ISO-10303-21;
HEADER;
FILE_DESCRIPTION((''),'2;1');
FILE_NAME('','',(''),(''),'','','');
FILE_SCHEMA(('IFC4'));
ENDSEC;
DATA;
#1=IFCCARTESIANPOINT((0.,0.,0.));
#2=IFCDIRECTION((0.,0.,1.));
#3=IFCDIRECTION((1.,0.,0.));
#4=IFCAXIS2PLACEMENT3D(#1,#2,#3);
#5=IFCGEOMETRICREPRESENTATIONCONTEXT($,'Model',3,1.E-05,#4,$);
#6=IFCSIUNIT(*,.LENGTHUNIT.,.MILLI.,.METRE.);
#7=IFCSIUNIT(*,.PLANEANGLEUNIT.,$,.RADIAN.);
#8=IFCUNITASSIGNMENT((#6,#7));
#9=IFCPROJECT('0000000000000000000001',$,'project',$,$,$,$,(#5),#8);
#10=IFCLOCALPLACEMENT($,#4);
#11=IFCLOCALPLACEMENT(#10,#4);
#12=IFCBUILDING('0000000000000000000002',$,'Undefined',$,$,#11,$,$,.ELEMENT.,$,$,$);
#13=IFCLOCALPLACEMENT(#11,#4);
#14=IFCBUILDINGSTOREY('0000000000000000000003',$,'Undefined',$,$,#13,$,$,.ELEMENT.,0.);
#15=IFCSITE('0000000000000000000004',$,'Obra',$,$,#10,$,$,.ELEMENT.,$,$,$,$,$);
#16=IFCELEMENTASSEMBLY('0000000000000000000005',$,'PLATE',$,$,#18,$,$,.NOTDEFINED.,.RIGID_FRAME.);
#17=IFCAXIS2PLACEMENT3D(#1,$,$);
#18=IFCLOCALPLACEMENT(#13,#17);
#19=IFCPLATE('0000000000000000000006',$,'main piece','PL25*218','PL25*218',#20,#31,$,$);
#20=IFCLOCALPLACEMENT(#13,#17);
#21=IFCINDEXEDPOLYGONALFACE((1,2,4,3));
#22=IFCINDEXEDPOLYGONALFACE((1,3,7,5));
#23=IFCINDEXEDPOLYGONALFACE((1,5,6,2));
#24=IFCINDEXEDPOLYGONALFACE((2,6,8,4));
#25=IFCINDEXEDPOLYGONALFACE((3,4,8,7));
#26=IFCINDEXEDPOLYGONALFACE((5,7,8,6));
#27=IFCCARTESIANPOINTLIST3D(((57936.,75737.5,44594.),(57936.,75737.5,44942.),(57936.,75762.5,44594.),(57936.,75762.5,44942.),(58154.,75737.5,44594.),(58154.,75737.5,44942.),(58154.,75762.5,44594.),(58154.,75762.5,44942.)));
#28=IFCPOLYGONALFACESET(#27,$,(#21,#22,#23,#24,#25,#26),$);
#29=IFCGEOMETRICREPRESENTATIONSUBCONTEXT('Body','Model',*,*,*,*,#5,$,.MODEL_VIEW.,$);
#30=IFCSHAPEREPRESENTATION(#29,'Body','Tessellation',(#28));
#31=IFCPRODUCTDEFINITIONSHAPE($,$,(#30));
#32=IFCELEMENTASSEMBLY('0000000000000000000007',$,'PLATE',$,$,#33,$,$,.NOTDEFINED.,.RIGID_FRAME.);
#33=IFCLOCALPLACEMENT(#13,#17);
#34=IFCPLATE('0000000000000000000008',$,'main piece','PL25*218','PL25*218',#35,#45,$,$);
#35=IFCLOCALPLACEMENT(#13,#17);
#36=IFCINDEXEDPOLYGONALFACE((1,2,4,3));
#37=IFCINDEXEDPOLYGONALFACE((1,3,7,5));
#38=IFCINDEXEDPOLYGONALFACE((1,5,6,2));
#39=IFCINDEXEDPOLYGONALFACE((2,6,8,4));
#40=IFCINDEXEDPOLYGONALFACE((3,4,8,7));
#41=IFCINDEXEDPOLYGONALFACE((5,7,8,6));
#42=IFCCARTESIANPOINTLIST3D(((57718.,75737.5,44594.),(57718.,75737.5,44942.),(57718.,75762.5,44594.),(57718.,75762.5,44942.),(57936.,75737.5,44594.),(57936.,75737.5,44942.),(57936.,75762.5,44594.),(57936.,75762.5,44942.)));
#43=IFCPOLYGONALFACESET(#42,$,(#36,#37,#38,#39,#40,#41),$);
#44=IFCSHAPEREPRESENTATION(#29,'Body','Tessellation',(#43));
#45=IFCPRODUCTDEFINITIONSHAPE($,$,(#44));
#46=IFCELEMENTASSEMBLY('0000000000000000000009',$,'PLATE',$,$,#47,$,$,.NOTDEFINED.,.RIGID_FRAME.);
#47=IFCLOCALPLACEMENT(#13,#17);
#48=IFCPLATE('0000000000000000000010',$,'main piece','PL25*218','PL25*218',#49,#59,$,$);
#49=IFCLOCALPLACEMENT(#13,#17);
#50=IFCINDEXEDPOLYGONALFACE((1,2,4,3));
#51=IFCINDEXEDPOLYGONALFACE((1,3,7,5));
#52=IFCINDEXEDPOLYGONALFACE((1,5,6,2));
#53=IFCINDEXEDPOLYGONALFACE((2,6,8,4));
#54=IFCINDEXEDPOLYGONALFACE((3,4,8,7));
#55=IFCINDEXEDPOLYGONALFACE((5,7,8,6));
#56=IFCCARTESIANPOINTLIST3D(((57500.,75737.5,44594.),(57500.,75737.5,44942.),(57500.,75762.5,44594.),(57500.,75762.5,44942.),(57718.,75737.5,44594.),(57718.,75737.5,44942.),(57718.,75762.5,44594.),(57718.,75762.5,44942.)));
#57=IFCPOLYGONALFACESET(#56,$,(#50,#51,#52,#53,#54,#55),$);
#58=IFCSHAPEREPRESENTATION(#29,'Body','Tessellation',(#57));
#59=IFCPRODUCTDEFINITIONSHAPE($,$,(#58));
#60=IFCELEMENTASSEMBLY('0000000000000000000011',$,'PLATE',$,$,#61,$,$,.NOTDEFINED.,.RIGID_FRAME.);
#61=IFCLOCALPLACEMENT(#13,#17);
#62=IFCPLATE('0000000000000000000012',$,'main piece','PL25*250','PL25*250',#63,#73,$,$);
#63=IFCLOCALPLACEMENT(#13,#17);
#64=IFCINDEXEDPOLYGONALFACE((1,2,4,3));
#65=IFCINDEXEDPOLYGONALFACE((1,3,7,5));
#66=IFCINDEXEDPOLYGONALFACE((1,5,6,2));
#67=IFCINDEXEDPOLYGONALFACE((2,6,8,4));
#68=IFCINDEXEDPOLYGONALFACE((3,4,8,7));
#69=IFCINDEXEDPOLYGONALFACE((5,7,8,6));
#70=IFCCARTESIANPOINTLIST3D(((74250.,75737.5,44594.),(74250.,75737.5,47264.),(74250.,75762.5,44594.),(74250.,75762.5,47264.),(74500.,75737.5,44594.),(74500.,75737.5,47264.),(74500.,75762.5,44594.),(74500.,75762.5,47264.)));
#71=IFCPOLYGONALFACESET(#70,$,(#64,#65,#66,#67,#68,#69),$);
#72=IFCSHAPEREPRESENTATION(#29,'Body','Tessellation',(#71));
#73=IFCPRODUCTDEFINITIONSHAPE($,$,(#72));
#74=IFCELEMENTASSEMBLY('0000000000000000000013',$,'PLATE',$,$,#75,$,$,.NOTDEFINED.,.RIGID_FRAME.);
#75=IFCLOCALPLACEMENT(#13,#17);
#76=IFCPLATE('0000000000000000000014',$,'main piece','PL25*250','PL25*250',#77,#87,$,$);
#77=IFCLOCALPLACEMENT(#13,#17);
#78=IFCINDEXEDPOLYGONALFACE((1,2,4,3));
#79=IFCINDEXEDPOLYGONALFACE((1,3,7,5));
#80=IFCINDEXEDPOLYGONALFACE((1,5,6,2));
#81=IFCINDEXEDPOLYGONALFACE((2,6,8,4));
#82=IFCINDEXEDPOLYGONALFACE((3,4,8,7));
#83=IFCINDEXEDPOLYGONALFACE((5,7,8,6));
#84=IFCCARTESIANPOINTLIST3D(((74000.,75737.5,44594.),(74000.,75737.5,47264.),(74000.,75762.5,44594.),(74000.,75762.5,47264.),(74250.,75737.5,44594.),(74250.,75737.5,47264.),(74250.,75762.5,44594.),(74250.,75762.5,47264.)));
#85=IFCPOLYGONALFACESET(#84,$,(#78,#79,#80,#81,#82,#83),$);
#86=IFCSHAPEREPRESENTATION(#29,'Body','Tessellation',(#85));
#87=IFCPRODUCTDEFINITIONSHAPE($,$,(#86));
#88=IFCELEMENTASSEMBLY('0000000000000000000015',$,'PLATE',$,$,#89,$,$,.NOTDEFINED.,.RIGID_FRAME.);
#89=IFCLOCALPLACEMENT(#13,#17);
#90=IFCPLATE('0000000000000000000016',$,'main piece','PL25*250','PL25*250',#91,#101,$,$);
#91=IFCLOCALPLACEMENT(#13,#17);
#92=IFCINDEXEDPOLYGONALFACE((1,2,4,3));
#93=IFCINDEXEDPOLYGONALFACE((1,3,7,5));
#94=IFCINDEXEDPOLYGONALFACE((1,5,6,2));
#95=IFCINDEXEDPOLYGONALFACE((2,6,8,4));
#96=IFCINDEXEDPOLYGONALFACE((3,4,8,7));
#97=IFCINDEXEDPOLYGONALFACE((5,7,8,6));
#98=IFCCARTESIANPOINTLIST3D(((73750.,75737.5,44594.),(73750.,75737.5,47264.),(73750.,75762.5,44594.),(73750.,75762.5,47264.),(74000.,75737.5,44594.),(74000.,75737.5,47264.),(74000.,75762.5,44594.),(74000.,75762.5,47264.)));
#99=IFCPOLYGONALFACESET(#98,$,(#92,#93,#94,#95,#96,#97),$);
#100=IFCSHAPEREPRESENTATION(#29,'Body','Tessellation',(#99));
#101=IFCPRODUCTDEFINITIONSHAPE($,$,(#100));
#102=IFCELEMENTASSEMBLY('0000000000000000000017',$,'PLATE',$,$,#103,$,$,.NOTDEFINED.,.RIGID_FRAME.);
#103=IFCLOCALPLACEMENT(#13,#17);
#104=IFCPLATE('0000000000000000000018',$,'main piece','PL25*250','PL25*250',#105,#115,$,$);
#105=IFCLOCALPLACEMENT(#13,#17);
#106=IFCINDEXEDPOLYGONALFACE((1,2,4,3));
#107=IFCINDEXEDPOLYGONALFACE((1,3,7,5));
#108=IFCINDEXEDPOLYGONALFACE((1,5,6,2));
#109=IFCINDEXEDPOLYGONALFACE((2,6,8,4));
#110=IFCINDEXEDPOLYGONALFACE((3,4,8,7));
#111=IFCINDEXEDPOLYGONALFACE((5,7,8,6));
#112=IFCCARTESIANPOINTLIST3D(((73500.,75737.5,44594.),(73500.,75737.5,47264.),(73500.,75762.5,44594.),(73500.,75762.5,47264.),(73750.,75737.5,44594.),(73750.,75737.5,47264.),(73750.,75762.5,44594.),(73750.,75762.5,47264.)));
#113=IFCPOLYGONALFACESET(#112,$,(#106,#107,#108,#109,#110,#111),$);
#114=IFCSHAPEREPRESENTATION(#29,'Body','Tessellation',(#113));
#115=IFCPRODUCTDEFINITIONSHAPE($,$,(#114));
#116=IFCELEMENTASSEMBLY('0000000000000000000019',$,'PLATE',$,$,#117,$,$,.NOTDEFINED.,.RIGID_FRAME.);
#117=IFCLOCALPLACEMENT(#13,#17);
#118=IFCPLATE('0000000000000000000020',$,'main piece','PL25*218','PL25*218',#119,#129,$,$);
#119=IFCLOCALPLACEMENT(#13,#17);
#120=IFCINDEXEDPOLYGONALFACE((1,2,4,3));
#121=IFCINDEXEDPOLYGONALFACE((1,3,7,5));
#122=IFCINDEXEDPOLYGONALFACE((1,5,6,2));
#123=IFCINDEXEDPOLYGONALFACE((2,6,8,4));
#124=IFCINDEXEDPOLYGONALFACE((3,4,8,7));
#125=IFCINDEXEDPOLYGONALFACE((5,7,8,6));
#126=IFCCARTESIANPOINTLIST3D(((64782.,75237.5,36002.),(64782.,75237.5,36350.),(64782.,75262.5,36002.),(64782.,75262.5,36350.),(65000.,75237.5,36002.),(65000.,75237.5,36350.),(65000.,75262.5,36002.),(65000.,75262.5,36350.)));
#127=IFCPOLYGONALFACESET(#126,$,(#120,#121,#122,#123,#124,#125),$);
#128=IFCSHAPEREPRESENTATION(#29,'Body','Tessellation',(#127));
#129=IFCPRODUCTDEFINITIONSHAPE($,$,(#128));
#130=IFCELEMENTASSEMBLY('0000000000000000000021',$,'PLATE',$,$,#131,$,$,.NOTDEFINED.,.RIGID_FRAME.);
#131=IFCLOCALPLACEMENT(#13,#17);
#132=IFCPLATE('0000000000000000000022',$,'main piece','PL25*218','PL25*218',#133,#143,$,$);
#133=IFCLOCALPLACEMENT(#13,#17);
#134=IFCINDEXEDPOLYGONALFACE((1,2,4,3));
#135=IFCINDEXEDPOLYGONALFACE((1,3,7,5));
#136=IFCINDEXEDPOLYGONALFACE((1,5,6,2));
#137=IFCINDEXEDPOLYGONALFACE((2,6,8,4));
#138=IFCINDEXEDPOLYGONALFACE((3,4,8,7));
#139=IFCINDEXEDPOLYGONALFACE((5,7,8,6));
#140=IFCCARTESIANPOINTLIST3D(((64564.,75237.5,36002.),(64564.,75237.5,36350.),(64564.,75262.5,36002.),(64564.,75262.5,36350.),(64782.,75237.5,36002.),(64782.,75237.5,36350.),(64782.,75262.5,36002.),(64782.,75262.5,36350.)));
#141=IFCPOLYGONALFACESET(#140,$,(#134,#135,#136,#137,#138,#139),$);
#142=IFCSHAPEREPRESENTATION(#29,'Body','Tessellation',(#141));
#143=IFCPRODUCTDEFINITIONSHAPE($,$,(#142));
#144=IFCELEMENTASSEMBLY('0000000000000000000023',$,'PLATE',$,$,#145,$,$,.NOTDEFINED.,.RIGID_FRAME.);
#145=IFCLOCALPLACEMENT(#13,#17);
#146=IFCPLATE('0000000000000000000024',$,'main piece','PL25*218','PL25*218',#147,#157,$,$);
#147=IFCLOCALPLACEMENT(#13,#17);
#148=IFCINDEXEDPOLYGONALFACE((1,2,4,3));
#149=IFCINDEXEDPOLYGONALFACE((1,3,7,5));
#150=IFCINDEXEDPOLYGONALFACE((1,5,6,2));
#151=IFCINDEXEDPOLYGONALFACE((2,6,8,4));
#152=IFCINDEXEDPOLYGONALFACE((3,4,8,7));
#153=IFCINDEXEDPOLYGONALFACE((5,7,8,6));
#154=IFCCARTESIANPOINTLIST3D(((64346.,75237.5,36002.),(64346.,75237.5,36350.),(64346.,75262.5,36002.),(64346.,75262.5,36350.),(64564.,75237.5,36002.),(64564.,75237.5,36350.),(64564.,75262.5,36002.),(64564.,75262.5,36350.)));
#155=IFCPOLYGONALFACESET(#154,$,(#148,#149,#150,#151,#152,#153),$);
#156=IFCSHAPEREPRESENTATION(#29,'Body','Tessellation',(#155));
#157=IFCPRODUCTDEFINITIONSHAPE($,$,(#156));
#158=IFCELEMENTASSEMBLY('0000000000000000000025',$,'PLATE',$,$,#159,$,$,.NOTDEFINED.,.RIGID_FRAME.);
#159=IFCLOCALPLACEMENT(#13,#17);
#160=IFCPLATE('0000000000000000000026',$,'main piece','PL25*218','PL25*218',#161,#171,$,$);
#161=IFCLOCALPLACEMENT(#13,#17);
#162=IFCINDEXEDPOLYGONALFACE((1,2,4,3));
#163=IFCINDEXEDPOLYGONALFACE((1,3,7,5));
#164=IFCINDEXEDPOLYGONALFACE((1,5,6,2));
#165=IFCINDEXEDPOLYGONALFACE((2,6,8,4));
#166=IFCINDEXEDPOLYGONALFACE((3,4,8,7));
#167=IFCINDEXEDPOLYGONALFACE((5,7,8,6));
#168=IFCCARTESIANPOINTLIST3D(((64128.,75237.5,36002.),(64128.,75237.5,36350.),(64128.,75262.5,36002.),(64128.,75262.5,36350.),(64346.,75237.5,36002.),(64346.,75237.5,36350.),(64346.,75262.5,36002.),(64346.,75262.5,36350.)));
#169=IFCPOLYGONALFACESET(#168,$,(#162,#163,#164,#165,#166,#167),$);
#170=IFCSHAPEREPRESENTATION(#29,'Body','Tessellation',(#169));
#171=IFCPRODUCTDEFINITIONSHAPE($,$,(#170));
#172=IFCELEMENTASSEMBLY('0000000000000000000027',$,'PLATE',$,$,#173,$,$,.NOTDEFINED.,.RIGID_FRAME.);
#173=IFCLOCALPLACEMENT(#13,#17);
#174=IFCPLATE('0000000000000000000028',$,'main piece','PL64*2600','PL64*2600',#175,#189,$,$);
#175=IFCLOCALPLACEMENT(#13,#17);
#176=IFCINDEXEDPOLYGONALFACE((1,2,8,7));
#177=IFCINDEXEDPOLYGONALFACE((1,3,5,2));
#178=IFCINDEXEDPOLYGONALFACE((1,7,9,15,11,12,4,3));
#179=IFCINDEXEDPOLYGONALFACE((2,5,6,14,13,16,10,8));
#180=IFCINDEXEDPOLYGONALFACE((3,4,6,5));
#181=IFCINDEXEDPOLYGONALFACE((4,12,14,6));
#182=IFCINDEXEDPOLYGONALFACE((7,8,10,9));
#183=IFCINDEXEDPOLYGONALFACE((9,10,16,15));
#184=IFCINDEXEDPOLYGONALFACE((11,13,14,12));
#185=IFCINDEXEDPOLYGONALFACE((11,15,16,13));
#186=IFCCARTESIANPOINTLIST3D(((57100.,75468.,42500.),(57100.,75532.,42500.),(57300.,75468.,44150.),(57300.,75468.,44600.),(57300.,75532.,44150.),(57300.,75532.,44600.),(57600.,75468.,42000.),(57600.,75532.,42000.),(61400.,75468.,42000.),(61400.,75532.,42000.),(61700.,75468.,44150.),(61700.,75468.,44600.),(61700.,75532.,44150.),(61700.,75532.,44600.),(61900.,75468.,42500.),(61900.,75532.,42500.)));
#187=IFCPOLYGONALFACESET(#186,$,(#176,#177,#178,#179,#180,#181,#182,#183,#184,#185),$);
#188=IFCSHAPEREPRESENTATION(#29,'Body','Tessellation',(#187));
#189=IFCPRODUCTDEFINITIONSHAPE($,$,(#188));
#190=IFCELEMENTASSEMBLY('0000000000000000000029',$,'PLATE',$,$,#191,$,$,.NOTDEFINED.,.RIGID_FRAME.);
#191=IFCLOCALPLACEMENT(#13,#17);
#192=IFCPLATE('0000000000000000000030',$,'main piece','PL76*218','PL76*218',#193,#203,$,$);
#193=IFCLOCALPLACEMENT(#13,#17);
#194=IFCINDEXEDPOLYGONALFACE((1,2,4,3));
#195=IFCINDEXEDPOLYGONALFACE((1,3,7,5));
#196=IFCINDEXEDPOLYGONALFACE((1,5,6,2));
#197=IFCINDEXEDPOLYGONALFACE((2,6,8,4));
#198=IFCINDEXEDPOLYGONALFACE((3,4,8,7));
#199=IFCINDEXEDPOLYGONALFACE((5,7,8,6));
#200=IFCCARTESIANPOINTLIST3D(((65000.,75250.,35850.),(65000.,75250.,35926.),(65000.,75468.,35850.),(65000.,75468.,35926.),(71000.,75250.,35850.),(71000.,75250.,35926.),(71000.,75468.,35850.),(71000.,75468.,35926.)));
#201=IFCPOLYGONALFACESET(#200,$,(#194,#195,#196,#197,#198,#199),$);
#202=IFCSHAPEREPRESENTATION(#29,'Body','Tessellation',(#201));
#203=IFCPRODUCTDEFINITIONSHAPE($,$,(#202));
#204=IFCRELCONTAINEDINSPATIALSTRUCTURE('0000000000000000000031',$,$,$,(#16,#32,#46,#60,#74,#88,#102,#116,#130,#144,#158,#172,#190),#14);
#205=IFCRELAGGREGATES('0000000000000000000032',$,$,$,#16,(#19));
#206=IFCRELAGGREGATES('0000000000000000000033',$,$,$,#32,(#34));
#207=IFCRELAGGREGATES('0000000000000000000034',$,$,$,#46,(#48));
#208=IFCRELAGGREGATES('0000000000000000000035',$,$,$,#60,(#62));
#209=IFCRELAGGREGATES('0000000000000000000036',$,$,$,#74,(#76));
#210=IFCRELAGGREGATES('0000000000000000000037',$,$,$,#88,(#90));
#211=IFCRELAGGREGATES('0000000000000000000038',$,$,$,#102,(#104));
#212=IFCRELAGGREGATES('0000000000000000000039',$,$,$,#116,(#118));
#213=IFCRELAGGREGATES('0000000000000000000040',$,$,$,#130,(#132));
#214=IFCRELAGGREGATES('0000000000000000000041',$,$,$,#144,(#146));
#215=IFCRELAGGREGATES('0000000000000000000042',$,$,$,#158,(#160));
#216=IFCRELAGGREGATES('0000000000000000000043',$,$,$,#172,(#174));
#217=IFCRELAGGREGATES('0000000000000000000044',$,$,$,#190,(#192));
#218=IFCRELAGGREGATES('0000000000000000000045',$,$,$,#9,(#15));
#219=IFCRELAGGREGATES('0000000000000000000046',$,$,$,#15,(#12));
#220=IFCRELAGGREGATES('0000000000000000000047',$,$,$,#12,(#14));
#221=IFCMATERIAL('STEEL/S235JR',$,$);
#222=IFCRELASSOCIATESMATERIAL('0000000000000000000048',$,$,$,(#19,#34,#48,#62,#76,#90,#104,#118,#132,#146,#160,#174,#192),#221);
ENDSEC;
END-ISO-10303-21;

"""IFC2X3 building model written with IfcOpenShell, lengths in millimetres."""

from ifc_helpers import new_model, si_unit, frame, origin_with_axes, place, context, subcontext, project, spatial, polyline, outline, extrude, material, element, aggregate, save


model = new_model("IFC2X3")

# Units and contexts
model_context = context("Model", 3, precision=1e-05, world=origin_with_axes())
body_context = subcontext(model_context, "Body", "Model", "MODEL_VIEW")
ifc_project = project(units=[si_unit("LENGTHUNIT", "METRE", prefix="MILLI"), si_unit("PLANEANGLEUNIT", "RADIAN")], contexts=[model_context])

# Site, building, storey
site_placement = place(None, origin_with_axes())
site = spatial("IfcSite", under=ifc_project, at=site_placement, Name="Obra", CompositionType="ELEMENT")
building_placement = place(site_placement, origin_with_axes())
building = spatial("IfcBuilding", under=site, at=building_placement, Name="Undefined", CompositionType="ELEMENT")
storey_placement = place(building_placement, origin_with_axes())
storey = spatial("IfcBuildingStorey", under=building, at=storey_placement, Name="Undefined", CompositionType="ELEMENT", Elevation=0.0)

# Shared definitions
ifc_material = material(Name="STEEL/S235JR")

# Element assemblies, plates
assembly_1_placement = place(storey_placement, origin_with_axes())
assembly_1 = element("IfcElementAssembly", 1, at=assembly_1_placement, inside=storey, Name="PLATE", AssemblyPlace="NOTDEFINED", PredefinedType="RIGID_FRAME")
plate_1_placement = place(assembly_1_placement, frame((57936.0, 75750.0, 44594.0), z_axis=(0.0, -1.0, 0.0), x_axis=(1.0, 0.0, 0.0)))
plate_1 = element("IfcPlate", 2, at=plate_1_placement, material=ifc_material, Name="main piece", Description="PL25*218", ObjectType="PL25*218", context=body_context, shape_type="SweptSolid", body=[
    extrude(outline(polyline([(0.0, 0.0), (218.0, 0.0), (218.0, 348.0), (0.0, 348.0), (0.0, 0.0)])), frame((0.0, 0.0, -12.5), z_axis=(0.0, 0.0, 1.0), x_axis=(1.0, 0.0, 0.0)), (0.0, 0.0, 1.0), 25.0),
])
aggregate(assembly_1, [plate_1])
assembly_2_placement = place(storey_placement, origin_with_axes())
assembly_2 = element("IfcElementAssembly", 3, at=assembly_2_placement, inside=storey, Name="PLATE", AssemblyPlace="NOTDEFINED", PredefinedType="RIGID_FRAME")
plate_2_placement = place(assembly_2_placement, frame((57718.0, 75750.0, 44594.0), z_axis=(0.0, -1.0, 0.0), x_axis=(1.0, 0.0, 0.0)))
plate_2 = element("IfcPlate", 4, at=plate_2_placement, material=ifc_material, Name="main piece", Description="PL25*218", ObjectType="PL25*218", context=body_context, shape_type="SweptSolid", body=[
    extrude(outline(polyline([(0.0, 0.0), (218.0, 0.0), (218.0, 348.0), (0.0, 348.0), (0.0, 0.0)])), frame((0.0, 0.0, -12.5), z_axis=(0.0, 0.0, 1.0), x_axis=(1.0, 0.0, 0.0)), (0.0, 0.0, 1.0), 25.0),
])
aggregate(assembly_2, [plate_2])
assembly_3_placement = place(storey_placement, origin_with_axes())
assembly_3 = element("IfcElementAssembly", 5, at=assembly_3_placement, inside=storey, Name="PLATE", AssemblyPlace="NOTDEFINED", PredefinedType="RIGID_FRAME")
plate_3_placement = place(assembly_3_placement, frame((57500.0, 75750.0, 44594.0), z_axis=(0.0, -1.0, 0.0), x_axis=(1.0, 0.0, 0.0)))
plate_3 = element("IfcPlate", 6, at=plate_3_placement, material=ifc_material, Name="main piece", Description="PL25*218", ObjectType="PL25*218", context=body_context, shape_type="SweptSolid", body=[
    extrude(outline(polyline([(0.0, 0.0), (218.0, 0.0), (218.0, 348.0), (0.0, 348.0), (0.0, 0.0)])), frame((0.0, 0.0, -12.5), z_axis=(0.0, 0.0, 1.0), x_axis=(1.0, 0.0, 0.0)), (0.0, 0.0, 1.0), 25.0),
])
aggregate(assembly_3, [plate_3])
assembly_4_placement = place(storey_placement, origin_with_axes())
assembly_4 = element("IfcElementAssembly", 7, at=assembly_4_placement, inside=storey, Name="PLATE", AssemblyPlace="NOTDEFINED", PredefinedType="RIGID_FRAME")
plate_4_placement = place(assembly_4_placement, frame((74250.0, 75750.0, 44594.0), z_axis=(0.0, -1.0, 0.0), x_axis=(1.0, 0.0, 0.0)))
plate_4 = element("IfcPlate", 8, at=plate_4_placement, material=ifc_material, Name="main piece", Description="PL25*250", ObjectType="PL25*250", context=body_context, shape_type="SweptSolid", body=[
    extrude(outline(polyline([(0.0, 0.0), (250.0, 0.0), (250.0, 2670.0), (0.0, 2670.0), (0.0, 0.0)])), frame((0.0, 0.0, -12.5), z_axis=(0.0, 0.0, 1.0), x_axis=(1.0, 0.0, 0.0)), (0.0, 0.0, 1.0), 25.0),
])
aggregate(assembly_4, [plate_4])
assembly_5_placement = place(storey_placement, origin_with_axes())
assembly_5 = element("IfcElementAssembly", 9, at=assembly_5_placement, inside=storey, Name="PLATE", AssemblyPlace="NOTDEFINED", PredefinedType="RIGID_FRAME")
plate_5_placement = place(assembly_5_placement, frame((74000.0, 75750.0, 44594.0), z_axis=(0.0, -1.0, 0.0), x_axis=(1.0, 0.0, 0.0)))
plate_5 = element("IfcPlate", 10, at=plate_5_placement, material=ifc_material, Name="main piece", Description="PL25*250", ObjectType="PL25*250", context=body_context, shape_type="SweptSolid", body=[
    extrude(outline(polyline([(0.0, 0.0), (250.0, 0.0), (250.0, 2670.0), (0.0, 2670.0), (0.0, 0.0)])), frame((0.0, 0.0, -12.5), z_axis=(0.0, 0.0, 1.0), x_axis=(1.0, 0.0, 0.0)), (0.0, 0.0, 1.0), 25.0),
])
aggregate(assembly_5, [plate_5])
assembly_6_placement = place(storey_placement, origin_with_axes())
assembly_6 = element("IfcElementAssembly", 11, at=assembly_6_placement, inside=storey, Name="PLATE", AssemblyPlace="NOTDEFINED", PredefinedType="RIGID_FRAME")
plate_6_placement = place(assembly_6_placement, frame((73750.0, 75750.0, 44594.0), z_axis=(0.0, -1.0, 0.0), x_axis=(1.0, 0.0, 0.0)))
plate_6 = element("IfcPlate", 12, at=plate_6_placement, material=ifc_material, Name="main piece", Description="PL25*250", ObjectType="PL25*250", context=body_context, shape_type="SweptSolid", body=[
    extrude(outline(polyline([(0.0, 0.0), (250.0, 0.0), (250.0, 2670.0), (0.0, 2670.0), (0.0, 0.0)])), frame((0.0, 0.0, -12.5), z_axis=(0.0, 0.0, 1.0), x_axis=(1.0, 0.0, 0.0)), (0.0, 0.0, 1.0), 25.0),
])
aggregate(assembly_6, [plate_6])
assembly_7_placement = place(storey_placement, origin_with_axes())
assembly_7 = element("IfcElementAssembly", 13, at=assembly_7_placement, inside=storey, Name="PLATE", AssemblyPlace="NOTDEFINED", PredefinedType="RIGID_FRAME")
plate_7_placement = place(assembly_7_placement, frame((73500.0, 75750.0, 44594.0), z_axis=(0.0, -1.0, 0.0), x_axis=(1.0, 0.0, 0.0)))
plate_7 = element("IfcPlate", 14, at=plate_7_placement, material=ifc_material, Name="main piece", Description="PL25*250", ObjectType="PL25*250", context=body_context, shape_type="SweptSolid", body=[
    extrude(outline(polyline([(0.0, 0.0), (250.0, 0.0), (250.0, 2670.0), (0.0, 2670.0), (0.0, 0.0)])), frame((0.0, 0.0, -12.5), z_axis=(0.0, 0.0, 1.0), x_axis=(1.0, 0.0, 0.0)), (0.0, 0.0, 1.0), 25.0),
])
aggregate(assembly_7, [plate_7])
assembly_8_placement = place(storey_placement, origin_with_axes())
assembly_8 = element("IfcElementAssembly", 15, at=assembly_8_placement, inside=storey, Name="PLATE", AssemblyPlace="NOTDEFINED", PredefinedType="RIGID_FRAME")
plate_8_placement = place(assembly_8_placement, frame((64782.0, 75250.0, 36002.0), z_axis=(0.0, -1.0, 0.0), x_axis=(1.0, 0.0, 0.0)))
plate_8 = element("IfcPlate", 16, at=plate_8_placement, material=ifc_material, Name="main piece", Description="PL25*218", ObjectType="PL25*218", context=body_context, shape_type="SweptSolid", body=[
    extrude(outline(polyline([(0.0, 0.0), (218.0, 0.0), (218.0, 348.0), (0.0, 348.0), (0.0, 0.0)])), frame((0.0, 0.0, -12.5), z_axis=(0.0, 0.0, 1.0), x_axis=(1.0, 0.0, 0.0)), (0.0, 0.0, 1.0), 25.0),
])
aggregate(assembly_8, [plate_8])
assembly_9_placement = place(storey_placement, origin_with_axes())
assembly_9 = element("IfcElementAssembly", 17, at=assembly_9_placement, inside=storey, Name="PLATE", AssemblyPlace="NOTDEFINED", PredefinedType="RIGID_FRAME")
plate_9_placement = place(assembly_9_placement, frame((64564.0, 75250.0, 36002.0), z_axis=(0.0, -1.0, 0.0), x_axis=(1.0, 0.0, 0.0)))
plate_9 = element("IfcPlate", 18, at=plate_9_placement, material=ifc_material, Name="main piece", Description="PL25*218", ObjectType="PL25*218", context=body_context, shape_type="SweptSolid", body=[
    extrude(outline(polyline([(0.0, 0.0), (218.0, 0.0), (218.0, 348.0), (0.0, 348.0), (0.0, 0.0)])), frame((0.0, 0.0, -12.5), z_axis=(0.0, 0.0, 1.0), x_axis=(1.0, 0.0, 0.0)), (0.0, 0.0, 1.0), 25.0),
])
aggregate(assembly_9, [plate_9])
assembly_10_placement = place(storey_placement, origin_with_axes())
assembly_10 = element("IfcElementAssembly", 19, at=assembly_10_placement, inside=storey, Name="PLATE", AssemblyPlace="NOTDEFINED", PredefinedType="RIGID_FRAME")
plate_10_placement = place(assembly_10_placement, frame((64346.0, 75250.0, 36002.0), z_axis=(0.0, -1.0, 0.0), x_axis=(1.0, 0.0, 0.0)))
plate_10 = element("IfcPlate", 20, at=plate_10_placement, material=ifc_material, Name="main piece", Description="PL25*218", ObjectType="PL25*218", context=body_context, shape_type="SweptSolid", body=[
    extrude(outline(polyline([(0.0, 0.0), (218.0, 0.0), (218.0, 348.0), (0.0, 348.0), (0.0, 0.0)])), frame((0.0, 0.0, -12.5), z_axis=(0.0, 0.0, 1.0), x_axis=(1.0, 0.0, 0.0)), (0.0, 0.0, 1.0), 25.0),
])
aggregate(assembly_10, [plate_10])
assembly_11_placement = place(storey_placement, origin_with_axes())
assembly_11 = element("IfcElementAssembly", 21, at=assembly_11_placement, inside=storey, Name="PLATE", AssemblyPlace="NOTDEFINED", PredefinedType="RIGID_FRAME")
plate_11_placement = place(assembly_11_placement, frame((64128.0, 75250.0, 36002.0), z_axis=(0.0, -1.0, 0.0), x_axis=(1.0, 0.0, 0.0)))
plate_11 = element("IfcPlate", 22, at=plate_11_placement, material=ifc_material, Name="main piece", Description="PL25*218", ObjectType="PL25*218", context=body_context, shape_type="SweptSolid", body=[
    extrude(outline(polyline([(0.0, 0.0), (218.0, 0.0), (218.0, 348.0), (0.0, 348.0), (0.0, 0.0)])), frame((0.0, 0.0, -12.5), z_axis=(0.0, 0.0, 1.0), x_axis=(1.0, 0.0, 0.0)), (0.0, 0.0, 1.0), 25.0),
])
aggregate(assembly_11, [plate_11])
assembly_12_placement = place(storey_placement, origin_with_axes())
assembly_12 = element("IfcElementAssembly", 23, at=assembly_12_placement, inside=storey, Name="PLATE", AssemblyPlace="NOTDEFINED", PredefinedType="RIGID_FRAME")
plate_12_placement = place(assembly_12_placement, frame((61700.0, 75500.0, 44600.0), z_axis=(0.0, -1.0, 0.0), x_axis=(-1.0, 0.0, 0.0)))
plate_12 = element("IfcPlate", 24, at=plate_12_placement, material=ifc_material, Name="main piece", Description="PL64*2600", ObjectType="PL64*2600", context=body_context, shape_type="SweptSolid", body=[
    extrude(outline(polyline([(0.0, 0.0), (4400.0, 0.0), (4400.0, 450.0), (4600.0, 2100.0), (4100.0, 2600.0), (300.0, 2600.0), (-200.0, 2100.0), (0.0, 450.0), (0.0, 0.0)])), frame((0.0, 0.0, -32.0), z_axis=(0.0, 0.0, 1.0), x_axis=(1.0, 0.0, 0.0)), (0.0, 0.0, 1.0), 64.0),
])
aggregate(assembly_12, [plate_12])
assembly_13_placement = place(storey_placement, origin_with_axes())
assembly_13 = element("IfcElementAssembly", 25, at=assembly_13_placement, inside=storey, Name="PLATE", AssemblyPlace="NOTDEFINED", PredefinedType="RIGID_FRAME")
plate_13_placement = place(assembly_13_placement, frame((65000.0, 75250.0, 35888.0), z_axis=(0.0, 0.0, -1.0), x_axis=(0.0, 1.0, 0.0)))
plate_13 = element("IfcPlate", 26, at=plate_13_placement, material=ifc_material, Name="main piece", Description="PL76*218", ObjectType="PL76*218", context=body_context, shape_type="SweptSolid", body=[
    extrude(outline(polyline([(0.0, 0.0), (218.0, 0.0), (218.0, 6000.0), (0.0, 6000.0), (0.0, 0.0)])), frame((0.0, 0.0, -38.0), z_axis=(0.0, 0.0, 1.0), x_axis=(1.0, 0.0, 0.0)), (0.0, 0.0, 1.0), 76.0),
])
aggregate(assembly_13, [plate_13])

save(model, "model.ifc")
